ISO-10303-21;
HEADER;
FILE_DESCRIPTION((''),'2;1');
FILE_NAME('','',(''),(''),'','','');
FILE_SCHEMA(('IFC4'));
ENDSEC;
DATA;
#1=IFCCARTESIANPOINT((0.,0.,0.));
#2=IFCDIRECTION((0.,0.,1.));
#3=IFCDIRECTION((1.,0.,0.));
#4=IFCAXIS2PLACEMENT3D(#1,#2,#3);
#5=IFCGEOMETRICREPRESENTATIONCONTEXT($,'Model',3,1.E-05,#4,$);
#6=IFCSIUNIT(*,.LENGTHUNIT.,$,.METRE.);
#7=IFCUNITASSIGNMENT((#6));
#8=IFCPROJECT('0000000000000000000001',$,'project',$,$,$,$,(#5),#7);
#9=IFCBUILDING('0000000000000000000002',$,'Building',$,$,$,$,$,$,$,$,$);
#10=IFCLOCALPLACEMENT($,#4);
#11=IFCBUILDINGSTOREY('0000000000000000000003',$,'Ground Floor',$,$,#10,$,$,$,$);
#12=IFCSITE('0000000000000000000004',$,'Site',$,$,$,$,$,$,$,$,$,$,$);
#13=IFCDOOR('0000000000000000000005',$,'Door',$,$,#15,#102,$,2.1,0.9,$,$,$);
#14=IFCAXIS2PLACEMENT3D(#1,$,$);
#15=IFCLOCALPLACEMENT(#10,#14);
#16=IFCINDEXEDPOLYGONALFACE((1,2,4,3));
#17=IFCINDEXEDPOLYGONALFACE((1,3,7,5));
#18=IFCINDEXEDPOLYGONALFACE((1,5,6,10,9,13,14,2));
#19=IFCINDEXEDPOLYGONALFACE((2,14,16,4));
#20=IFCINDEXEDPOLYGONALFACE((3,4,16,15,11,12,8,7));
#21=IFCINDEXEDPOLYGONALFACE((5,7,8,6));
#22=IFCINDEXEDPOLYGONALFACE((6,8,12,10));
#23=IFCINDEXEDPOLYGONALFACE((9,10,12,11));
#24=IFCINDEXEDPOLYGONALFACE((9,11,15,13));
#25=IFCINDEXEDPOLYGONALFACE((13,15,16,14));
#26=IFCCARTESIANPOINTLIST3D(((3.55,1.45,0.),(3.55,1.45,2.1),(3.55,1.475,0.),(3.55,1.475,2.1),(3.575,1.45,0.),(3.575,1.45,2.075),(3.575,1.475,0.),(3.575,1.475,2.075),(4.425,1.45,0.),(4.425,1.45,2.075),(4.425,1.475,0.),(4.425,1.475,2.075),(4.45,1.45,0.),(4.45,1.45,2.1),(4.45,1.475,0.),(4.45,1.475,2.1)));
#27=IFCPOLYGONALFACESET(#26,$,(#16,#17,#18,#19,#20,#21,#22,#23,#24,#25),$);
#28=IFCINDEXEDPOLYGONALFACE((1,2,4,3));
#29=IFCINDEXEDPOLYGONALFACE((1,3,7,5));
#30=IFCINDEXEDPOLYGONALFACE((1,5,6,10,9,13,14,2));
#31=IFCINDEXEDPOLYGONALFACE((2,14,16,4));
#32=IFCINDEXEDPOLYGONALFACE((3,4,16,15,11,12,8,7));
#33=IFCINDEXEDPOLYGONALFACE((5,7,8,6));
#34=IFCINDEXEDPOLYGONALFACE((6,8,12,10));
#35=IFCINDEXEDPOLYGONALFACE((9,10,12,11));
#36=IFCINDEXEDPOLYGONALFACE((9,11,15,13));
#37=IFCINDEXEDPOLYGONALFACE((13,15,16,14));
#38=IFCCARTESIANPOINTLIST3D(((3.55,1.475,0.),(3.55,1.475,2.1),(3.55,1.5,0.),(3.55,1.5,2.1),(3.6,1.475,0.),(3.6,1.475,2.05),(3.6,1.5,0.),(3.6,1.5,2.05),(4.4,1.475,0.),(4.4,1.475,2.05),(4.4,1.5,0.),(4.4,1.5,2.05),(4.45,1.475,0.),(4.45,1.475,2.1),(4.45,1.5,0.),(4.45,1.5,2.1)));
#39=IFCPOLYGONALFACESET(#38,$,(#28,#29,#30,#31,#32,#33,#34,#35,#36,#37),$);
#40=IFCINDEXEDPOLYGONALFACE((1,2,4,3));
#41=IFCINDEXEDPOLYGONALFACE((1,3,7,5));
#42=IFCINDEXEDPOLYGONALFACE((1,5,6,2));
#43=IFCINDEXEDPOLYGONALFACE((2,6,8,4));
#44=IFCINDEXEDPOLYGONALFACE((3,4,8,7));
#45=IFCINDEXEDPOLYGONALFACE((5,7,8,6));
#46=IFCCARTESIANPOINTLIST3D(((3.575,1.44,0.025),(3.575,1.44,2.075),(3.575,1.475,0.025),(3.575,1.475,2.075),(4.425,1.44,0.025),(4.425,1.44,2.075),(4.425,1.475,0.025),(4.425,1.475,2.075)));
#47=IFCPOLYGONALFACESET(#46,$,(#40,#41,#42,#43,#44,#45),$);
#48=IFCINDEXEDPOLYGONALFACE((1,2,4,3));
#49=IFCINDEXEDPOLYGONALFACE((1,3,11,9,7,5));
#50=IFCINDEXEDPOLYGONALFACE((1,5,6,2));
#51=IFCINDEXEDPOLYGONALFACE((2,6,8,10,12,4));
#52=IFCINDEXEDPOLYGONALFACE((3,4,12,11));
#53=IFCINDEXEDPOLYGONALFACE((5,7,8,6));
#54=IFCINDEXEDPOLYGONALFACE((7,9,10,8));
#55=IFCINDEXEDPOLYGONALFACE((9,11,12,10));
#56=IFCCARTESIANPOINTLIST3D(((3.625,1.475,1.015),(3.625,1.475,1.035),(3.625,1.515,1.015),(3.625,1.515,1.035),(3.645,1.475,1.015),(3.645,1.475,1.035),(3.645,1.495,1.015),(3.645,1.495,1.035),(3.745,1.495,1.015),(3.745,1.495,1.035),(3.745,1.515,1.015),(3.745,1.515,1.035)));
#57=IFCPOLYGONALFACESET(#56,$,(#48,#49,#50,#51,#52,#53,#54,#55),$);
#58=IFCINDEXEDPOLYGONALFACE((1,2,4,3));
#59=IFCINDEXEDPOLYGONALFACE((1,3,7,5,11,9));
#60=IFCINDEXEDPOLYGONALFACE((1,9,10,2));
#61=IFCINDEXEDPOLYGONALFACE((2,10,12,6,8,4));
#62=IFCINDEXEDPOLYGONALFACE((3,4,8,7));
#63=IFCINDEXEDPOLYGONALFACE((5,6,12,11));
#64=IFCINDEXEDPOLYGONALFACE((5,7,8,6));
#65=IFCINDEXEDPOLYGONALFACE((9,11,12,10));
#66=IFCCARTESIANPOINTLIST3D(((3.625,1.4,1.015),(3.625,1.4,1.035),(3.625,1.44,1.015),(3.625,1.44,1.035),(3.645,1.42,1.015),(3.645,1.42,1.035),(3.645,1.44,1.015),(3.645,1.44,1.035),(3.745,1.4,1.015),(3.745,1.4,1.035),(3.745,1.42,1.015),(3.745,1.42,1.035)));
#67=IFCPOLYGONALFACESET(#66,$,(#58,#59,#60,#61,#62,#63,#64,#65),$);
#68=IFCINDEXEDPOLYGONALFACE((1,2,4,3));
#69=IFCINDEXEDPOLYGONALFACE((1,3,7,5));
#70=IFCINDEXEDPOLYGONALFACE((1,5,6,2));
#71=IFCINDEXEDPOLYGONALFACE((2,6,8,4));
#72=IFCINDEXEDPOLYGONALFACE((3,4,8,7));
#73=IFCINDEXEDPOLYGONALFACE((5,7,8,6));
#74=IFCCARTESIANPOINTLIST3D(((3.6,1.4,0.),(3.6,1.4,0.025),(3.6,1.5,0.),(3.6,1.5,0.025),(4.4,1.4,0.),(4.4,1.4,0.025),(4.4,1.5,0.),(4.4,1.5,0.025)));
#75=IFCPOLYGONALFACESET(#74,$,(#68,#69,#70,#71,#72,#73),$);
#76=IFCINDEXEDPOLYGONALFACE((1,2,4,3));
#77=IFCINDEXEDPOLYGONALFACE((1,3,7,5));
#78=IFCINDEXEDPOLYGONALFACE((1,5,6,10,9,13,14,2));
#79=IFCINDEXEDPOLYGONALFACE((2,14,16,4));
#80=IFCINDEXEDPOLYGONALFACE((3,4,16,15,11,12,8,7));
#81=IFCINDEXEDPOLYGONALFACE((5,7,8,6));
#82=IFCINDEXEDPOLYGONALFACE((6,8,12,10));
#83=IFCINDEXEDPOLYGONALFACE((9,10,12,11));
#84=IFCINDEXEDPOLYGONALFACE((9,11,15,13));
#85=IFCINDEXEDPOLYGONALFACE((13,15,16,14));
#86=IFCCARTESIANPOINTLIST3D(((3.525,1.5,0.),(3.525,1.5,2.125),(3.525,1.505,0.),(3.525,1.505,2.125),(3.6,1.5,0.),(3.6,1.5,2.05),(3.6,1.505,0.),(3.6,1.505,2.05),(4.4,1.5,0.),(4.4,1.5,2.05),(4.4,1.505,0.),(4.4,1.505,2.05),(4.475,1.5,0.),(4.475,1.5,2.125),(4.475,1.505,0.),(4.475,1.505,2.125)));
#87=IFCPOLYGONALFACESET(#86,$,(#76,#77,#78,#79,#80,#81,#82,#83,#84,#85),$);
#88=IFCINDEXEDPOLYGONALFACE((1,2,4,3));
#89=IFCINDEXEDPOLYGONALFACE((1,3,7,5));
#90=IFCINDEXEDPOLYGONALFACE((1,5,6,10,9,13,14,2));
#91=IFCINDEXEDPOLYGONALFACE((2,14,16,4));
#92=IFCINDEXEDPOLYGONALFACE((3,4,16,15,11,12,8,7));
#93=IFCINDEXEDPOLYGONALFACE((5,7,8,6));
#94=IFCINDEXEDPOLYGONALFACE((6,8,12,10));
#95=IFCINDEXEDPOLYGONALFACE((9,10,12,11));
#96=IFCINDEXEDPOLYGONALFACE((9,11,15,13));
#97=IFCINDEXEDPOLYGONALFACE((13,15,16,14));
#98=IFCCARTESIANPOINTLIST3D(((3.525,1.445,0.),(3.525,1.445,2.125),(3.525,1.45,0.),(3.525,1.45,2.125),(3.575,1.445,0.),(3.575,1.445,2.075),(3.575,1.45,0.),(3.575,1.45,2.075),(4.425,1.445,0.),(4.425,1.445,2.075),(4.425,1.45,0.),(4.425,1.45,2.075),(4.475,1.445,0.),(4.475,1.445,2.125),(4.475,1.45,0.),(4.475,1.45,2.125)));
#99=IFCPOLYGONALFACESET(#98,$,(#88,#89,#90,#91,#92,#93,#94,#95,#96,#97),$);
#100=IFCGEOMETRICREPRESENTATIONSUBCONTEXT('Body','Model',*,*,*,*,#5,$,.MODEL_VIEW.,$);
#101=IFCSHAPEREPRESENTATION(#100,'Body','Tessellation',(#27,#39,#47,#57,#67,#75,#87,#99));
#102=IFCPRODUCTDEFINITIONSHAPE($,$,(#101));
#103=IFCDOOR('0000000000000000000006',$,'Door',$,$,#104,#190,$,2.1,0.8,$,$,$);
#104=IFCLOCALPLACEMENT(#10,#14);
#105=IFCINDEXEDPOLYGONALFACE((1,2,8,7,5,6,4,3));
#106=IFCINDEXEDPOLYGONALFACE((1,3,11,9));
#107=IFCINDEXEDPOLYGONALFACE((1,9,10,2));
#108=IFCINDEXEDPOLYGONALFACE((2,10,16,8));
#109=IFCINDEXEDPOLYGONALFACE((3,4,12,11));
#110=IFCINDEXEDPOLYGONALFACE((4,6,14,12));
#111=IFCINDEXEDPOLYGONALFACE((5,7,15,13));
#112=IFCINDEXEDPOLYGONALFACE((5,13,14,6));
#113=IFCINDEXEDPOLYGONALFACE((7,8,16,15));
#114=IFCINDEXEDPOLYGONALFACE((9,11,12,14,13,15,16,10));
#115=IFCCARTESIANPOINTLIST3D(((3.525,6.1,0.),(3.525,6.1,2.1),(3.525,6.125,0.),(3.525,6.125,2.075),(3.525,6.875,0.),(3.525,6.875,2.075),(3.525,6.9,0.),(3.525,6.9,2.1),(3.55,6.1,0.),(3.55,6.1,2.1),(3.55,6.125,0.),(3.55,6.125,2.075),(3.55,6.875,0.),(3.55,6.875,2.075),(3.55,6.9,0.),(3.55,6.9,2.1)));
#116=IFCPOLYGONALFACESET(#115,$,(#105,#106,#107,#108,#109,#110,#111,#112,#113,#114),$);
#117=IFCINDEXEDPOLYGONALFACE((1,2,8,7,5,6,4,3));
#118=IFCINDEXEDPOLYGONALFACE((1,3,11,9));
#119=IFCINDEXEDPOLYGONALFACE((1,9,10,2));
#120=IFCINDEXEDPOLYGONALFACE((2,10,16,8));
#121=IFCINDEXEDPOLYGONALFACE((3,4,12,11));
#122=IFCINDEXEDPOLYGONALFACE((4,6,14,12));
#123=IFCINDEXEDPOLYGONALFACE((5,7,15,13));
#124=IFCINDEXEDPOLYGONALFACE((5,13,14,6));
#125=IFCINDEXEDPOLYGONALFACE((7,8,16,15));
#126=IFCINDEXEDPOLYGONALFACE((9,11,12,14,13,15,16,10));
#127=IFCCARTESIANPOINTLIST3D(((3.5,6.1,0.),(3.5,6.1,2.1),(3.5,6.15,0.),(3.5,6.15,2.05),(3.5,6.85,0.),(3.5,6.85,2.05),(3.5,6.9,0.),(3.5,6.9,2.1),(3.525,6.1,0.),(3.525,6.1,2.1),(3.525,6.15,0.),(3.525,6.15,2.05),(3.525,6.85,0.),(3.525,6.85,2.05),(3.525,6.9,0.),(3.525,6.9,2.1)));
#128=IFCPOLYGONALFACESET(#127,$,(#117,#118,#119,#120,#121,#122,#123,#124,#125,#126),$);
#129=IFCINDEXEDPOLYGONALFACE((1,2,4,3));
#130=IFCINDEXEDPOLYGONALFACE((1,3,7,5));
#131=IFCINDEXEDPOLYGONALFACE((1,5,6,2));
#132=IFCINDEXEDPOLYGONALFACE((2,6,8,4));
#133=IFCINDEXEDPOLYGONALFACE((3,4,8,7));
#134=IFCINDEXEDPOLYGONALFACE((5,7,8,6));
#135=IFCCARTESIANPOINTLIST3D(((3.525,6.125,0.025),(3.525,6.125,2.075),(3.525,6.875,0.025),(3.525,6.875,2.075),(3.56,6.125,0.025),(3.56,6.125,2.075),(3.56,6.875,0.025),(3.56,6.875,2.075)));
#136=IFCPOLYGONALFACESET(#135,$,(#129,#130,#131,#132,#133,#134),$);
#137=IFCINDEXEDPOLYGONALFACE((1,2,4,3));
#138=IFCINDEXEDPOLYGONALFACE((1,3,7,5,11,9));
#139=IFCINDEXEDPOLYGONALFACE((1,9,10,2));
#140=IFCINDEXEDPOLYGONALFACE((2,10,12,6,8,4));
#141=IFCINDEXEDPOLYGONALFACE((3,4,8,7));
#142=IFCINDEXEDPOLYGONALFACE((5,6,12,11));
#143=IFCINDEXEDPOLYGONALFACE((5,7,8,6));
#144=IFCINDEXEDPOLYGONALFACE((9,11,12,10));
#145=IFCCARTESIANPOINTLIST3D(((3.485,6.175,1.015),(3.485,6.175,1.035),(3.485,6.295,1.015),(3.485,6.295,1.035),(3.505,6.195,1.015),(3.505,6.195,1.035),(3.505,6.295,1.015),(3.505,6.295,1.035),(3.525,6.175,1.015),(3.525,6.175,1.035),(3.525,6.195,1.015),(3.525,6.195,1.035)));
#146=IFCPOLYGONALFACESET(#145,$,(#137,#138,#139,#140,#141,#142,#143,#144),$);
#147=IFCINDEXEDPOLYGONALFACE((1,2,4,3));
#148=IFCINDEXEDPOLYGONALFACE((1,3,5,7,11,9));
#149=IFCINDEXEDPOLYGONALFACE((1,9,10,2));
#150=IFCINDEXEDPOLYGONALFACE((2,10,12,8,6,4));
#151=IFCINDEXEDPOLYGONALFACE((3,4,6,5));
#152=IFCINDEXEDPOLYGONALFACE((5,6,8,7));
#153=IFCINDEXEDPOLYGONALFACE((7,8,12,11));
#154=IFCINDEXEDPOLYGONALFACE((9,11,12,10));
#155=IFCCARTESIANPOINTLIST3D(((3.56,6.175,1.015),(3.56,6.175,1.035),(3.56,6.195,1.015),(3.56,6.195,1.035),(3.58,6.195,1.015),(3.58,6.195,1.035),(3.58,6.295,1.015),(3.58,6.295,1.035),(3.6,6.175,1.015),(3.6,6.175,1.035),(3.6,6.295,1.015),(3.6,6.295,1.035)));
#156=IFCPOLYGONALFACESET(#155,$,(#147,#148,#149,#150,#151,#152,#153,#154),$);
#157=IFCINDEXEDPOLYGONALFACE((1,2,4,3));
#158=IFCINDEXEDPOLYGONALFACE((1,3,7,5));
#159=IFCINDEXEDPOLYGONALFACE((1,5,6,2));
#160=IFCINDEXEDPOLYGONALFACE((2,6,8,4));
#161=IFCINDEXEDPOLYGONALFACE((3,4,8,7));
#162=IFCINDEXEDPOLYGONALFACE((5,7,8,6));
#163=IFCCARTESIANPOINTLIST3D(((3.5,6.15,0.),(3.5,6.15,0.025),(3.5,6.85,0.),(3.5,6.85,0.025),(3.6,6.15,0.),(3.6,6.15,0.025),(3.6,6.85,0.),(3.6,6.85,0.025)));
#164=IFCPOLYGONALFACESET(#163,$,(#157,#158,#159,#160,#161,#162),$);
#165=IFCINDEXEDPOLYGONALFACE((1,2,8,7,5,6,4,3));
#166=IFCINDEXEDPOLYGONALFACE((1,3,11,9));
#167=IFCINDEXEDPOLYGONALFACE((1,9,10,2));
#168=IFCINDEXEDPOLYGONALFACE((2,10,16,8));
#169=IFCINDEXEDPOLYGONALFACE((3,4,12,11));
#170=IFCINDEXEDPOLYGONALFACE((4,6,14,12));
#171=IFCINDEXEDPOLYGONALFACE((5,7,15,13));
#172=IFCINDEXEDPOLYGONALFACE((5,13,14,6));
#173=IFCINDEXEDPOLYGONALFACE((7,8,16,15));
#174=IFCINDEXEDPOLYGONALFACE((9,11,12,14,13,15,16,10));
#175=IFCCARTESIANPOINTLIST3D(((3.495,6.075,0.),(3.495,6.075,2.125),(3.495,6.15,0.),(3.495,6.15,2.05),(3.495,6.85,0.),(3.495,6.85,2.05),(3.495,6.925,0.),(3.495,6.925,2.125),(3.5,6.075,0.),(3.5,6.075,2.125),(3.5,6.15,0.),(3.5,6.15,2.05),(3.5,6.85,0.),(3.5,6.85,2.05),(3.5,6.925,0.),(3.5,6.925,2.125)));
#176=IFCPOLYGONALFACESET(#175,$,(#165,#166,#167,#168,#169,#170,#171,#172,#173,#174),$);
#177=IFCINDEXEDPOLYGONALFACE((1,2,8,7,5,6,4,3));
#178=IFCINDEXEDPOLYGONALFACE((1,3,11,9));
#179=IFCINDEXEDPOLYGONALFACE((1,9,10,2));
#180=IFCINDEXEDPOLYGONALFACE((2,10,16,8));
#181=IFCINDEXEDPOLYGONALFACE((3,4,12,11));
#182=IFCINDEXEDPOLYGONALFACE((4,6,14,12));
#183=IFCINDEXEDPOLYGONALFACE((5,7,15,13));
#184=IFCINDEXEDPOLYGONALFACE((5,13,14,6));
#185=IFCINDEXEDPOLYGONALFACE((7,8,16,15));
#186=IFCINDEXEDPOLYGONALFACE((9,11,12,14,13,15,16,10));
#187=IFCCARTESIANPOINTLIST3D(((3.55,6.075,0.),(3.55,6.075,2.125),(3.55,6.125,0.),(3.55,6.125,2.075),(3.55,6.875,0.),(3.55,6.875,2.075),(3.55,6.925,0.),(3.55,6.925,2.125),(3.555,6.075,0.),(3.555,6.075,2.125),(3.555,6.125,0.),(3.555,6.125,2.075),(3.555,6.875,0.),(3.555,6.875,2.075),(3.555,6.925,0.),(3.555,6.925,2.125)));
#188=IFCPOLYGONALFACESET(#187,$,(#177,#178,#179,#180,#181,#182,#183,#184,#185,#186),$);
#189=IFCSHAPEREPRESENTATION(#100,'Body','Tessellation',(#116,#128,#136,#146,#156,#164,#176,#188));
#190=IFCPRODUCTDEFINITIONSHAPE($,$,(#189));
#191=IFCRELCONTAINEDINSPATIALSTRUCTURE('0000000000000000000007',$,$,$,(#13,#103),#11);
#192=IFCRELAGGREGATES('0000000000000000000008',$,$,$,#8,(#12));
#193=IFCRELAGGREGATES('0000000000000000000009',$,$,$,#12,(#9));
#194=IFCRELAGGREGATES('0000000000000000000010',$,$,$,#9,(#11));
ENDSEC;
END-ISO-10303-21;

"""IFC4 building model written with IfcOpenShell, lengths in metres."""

from ifc_helpers import new_model, si_unit, frame, origin_with_axes, place, context, subcontext, project, spatial, line, indexed_curve, outline, extrude, element, save


model = new_model("IFC4")

# Units and contexts
model_context = context("Model", 3, precision=1e-05, world=origin_with_axes())
body_context = subcontext(model_context, "Body", "Model", "MODEL_VIEW")
ifc_project = project(units=[si_unit("LENGTHUNIT", "METRE")], contexts=[model_context])

# Site, building, storey
site = spatial("IfcSite", under=ifc_project, Name="Site")
building = spatial("IfcBuilding", under=site, Name="Building")
storey_placement = place(None, origin_with_axes())
storey = spatial("IfcBuildingStorey", under=building, at=storey_placement, Name="Ground Floor")

# Doors
door_1_placement = place(storey_placement, frame((4.45, 1.5, 0.0), z_axis=(0.0, 0.0, 1.0), x_axis=(-1.0, 0.0, 0.0)))
element("IfcDoor", 1, at=door_1_placement, inside=storey, Name="Door", OverallHeight=2.1, OverallWidth=0.9, context=body_context, shape_type="SweptSolid", body=[
    extrude(outline(indexed_curve([(0.0, 0.0), (0.0, 2.1), (0.9, 2.1), (0.9, 0.0), (0.875, 0.0), (0.875, 2.075), (0.025, 2.075), (0.025, 0.0)], segments=[line(1, 2, 3, 4, 5, 6, 7, 8, 1)])), frame((0.0, 0.025, 0.0), z_axis=(0.0, -1.0, 0.0), x_axis=(1.0, 0.0, 0.0)), (0.0, 0.0, -1.0), 0.025),
    extrude(outline(indexed_curve([(0.0, 0.0), (0.0, 2.1), (0.9, 2.1), (0.9, 0.0), (0.85, 0.0), (0.85, 2.05), (0.05, 2.05), (0.05, 0.0)], segments=[line(1, 2, 3, 4, 5, 6, 7, 8, 1)])), frame((0.0, 0.0, 0.0), z_axis=(0.0, -1.0, 0.0), x_axis=(1.0, 0.0, 0.0)), (0.0, 0.0, -1.0), 0.025),
    extrude(outline(indexed_curve([(0.0, 0.0), (0.85, 0.0), (0.85, 0.035), (0.0, 0.035)], segments=[line(1, 2, 3, 4, 1)])), frame((0.025, 0.025, 0.025), z_axis=(0.0, 0.0, 1.0), x_axis=(1.0, 0.0, 0.0)), (0.0, 0.0, 1.0), 2.05),
    extrude(outline(indexed_curve([(0.0, 0.0), (0.0, -0.04), (-0.12, -0.04), (-0.12, -0.02), (-0.02, -0.02), (-0.02, 0.0)], segments=[line(1, 2, 3, 4, 5, 6, 1)])), frame((0.825, 0.025, 1.015), z_axis=(0.0, 0.0, 1.0), x_axis=(1.0, 0.0, 0.0)), (0.0, 0.0, 1.0), 0.02),
    extrude(outline(indexed_curve([(0.0, 0.0), (0.0, 0.04), (-0.12, 0.04), (-0.12, 0.02), (-0.02, 0.02), (-0.02, 0.0)], segments=[line(1, 2, 3, 4, 5, 6, 1)])), frame((0.825, 0.06, 1.015), z_axis=(0.0, 0.0, 1.0), x_axis=(1.0, 0.0, 0.0)), (0.0, 0.0, 1.0), 0.02),
    extrude(outline(indexed_curve([(0.0, 0.0), (0.8, 0.0), (0.8, 0.1), (0.0, 0.1)], segments=[line(1, 2, 3, 4, 1)])), frame((0.05, 0.0, 0.0), z_axis=(0.0, 0.0, 1.0), x_axis=(1.0, 0.0, 0.0)), (0.0, 0.0, 1.0), 0.025),
    extrude(outline(indexed_curve([(0.0, 0.0), (0.0, 2.125), (0.95, 2.125), (0.95, 0.0), (0.875, 0.0), (0.875, 2.05), (0.075, 2.05), (0.075, 0.0)], segments=[line(1, 2, 3, 4, 5, 6, 7, 8, 1)])), frame((-0.025, -0.005, 0.0), z_axis=(0.0, -1.0, 0.0), x_axis=(1.0, 0.0, 0.0)), (0.0, 0.0, -1.0), 0.005),
    extrude(outline(indexed_curve([(0.0, 0.0), (0.0, 2.125), (0.95, 2.125), (0.95, 0.0), (0.9, 0.0), (0.9, 2.075), (0.05, 2.075), (0.05, 0.0)], segments=[line(1, 2, 3, 4, 5, 6, 7, 8, 1)])), frame((-0.025, 0.05, 0.0), z_axis=(0.0, -1.0, 0.0), x_axis=(1.0, 0.0, 0.0)), (0.0, 0.0, -1.0), 0.005),
])
door_2_placement = place(storey_placement, frame((3.5, 6.9, 0.0), z_axis=(0.0, 0.0, 1.0), x_axis=(0.0, -1.0, 0.0)))
element("IfcDoor", 2, at=door_2_placement, inside=storey, Name="Door", OverallHeight=2.1, OverallWidth=0.8, context=body_context, shape_type="SweptSolid", body=[
    extrude(outline(indexed_curve([(0.0, 0.0), (0.0, 2.1), (0.8, 2.1), (0.8, 0.0), (0.775, 0.0), (0.775, 2.075), (0.025, 2.075), (0.025, 0.0)], segments=[line(1, 2, 3, 4, 5, 6, 7, 8, 1)])), frame((0.0, 0.025, 0.0), z_axis=(0.0, -1.0, 0.0), x_axis=(1.0, 0.0, 0.0)), (0.0, 0.0, -1.0), 0.025),
    extrude(outline(indexed_curve([(0.0, 0.0), (0.0, 2.1), (0.8, 2.1), (0.8, 0.0), (0.75, 0.0), (0.75, 2.05), (0.05, 2.05), (0.05, 0.0)], segments=[line(1, 2, 3, 4, 5, 6, 7, 8, 1)])), frame((0.0, 0.0, 0.0), z_axis=(0.0, -1.0, 0.0), x_axis=(1.0, 0.0, 0.0)), (0.0, 0.0, -1.0), 0.025),
    extrude(outline(indexed_curve([(0.0, 0.0), (0.75, 0.0), (0.75, 0.035), (0.0, 0.035)], segments=[line(1, 2, 3, 4, 1)])), frame((0.025, 0.025, 0.025), z_axis=(0.0, 0.0, 1.0), x_axis=(1.0, 0.0, 0.0)), (0.0, 0.0, 1.0), 2.05),
    extrude(outline(indexed_curve([(0.0, 0.0), (0.0, -0.04), (-0.12, -0.04), (-0.12, -0.02), (-0.02, -0.02), (-0.02, 0.0)], segments=[line(1, 2, 3, 4, 5, 6, 1)])), frame((0.725, 0.025, 1.015), z_axis=(0.0, 0.0, 1.0), x_axis=(1.0, 0.0, 0.0)), (0.0, 0.0, 1.0), 0.02),
    extrude(outline(indexed_curve([(0.0, 0.0), (0.0, 0.04), (-0.12, 0.04), (-0.12, 0.02), (-0.02, 0.02), (-0.02, 0.0)], segments=[line(1, 2, 3, 4, 5, 6, 1)])), frame((0.725, 0.06, 1.015), z_axis=(0.0, 0.0, 1.0), x_axis=(1.0, 0.0, 0.0)), (0.0, 0.0, 1.0), 0.02),
    extrude(outline(indexed_curve([(0.0, 0.0), (0.7, 0.0), (0.7, 0.1), (0.0, 0.1)], segments=[line(1, 2, 3, 4, 1)])), frame((0.05, 0.0, 0.0), z_axis=(0.0, 0.0, 1.0), x_axis=(1.0, 0.0, 0.0)), (0.0, 0.0, 1.0), 0.025),
    extrude(outline(indexed_curve([(0.0, 0.0), (0.0, 2.125), (0.85, 2.125), (0.85, 0.0), (0.775, 0.0), (0.775, 2.05), (0.075, 2.05), (0.075, 0.0)], segments=[line(1, 2, 3, 4, 5, 6, 7, 8, 1)])), frame((-0.025, -0.005, 0.0), z_axis=(0.0, -1.0, 0.0), x_axis=(1.0, 0.0, 0.0)), (0.0, 0.0, -1.0), 0.005),
    extrude(outline(indexed_curve([(0.0, 0.0), (0.0, 2.125), (0.85, 2.125), (0.85, 0.0), (0.8, 0.0), (0.8, 2.075), (0.05, 2.075), (0.05, 0.0)], segments=[line(1, 2, 3, 4, 5, 6, 7, 8, 1)])), frame((-0.025, 0.05, 0.0), z_axis=(0.0, -1.0, 0.0), x_axis=(1.0, 0.0, 0.0)), (0.0, 0.0, -1.0), 0.005),
])

save(model, "model.ifc")
